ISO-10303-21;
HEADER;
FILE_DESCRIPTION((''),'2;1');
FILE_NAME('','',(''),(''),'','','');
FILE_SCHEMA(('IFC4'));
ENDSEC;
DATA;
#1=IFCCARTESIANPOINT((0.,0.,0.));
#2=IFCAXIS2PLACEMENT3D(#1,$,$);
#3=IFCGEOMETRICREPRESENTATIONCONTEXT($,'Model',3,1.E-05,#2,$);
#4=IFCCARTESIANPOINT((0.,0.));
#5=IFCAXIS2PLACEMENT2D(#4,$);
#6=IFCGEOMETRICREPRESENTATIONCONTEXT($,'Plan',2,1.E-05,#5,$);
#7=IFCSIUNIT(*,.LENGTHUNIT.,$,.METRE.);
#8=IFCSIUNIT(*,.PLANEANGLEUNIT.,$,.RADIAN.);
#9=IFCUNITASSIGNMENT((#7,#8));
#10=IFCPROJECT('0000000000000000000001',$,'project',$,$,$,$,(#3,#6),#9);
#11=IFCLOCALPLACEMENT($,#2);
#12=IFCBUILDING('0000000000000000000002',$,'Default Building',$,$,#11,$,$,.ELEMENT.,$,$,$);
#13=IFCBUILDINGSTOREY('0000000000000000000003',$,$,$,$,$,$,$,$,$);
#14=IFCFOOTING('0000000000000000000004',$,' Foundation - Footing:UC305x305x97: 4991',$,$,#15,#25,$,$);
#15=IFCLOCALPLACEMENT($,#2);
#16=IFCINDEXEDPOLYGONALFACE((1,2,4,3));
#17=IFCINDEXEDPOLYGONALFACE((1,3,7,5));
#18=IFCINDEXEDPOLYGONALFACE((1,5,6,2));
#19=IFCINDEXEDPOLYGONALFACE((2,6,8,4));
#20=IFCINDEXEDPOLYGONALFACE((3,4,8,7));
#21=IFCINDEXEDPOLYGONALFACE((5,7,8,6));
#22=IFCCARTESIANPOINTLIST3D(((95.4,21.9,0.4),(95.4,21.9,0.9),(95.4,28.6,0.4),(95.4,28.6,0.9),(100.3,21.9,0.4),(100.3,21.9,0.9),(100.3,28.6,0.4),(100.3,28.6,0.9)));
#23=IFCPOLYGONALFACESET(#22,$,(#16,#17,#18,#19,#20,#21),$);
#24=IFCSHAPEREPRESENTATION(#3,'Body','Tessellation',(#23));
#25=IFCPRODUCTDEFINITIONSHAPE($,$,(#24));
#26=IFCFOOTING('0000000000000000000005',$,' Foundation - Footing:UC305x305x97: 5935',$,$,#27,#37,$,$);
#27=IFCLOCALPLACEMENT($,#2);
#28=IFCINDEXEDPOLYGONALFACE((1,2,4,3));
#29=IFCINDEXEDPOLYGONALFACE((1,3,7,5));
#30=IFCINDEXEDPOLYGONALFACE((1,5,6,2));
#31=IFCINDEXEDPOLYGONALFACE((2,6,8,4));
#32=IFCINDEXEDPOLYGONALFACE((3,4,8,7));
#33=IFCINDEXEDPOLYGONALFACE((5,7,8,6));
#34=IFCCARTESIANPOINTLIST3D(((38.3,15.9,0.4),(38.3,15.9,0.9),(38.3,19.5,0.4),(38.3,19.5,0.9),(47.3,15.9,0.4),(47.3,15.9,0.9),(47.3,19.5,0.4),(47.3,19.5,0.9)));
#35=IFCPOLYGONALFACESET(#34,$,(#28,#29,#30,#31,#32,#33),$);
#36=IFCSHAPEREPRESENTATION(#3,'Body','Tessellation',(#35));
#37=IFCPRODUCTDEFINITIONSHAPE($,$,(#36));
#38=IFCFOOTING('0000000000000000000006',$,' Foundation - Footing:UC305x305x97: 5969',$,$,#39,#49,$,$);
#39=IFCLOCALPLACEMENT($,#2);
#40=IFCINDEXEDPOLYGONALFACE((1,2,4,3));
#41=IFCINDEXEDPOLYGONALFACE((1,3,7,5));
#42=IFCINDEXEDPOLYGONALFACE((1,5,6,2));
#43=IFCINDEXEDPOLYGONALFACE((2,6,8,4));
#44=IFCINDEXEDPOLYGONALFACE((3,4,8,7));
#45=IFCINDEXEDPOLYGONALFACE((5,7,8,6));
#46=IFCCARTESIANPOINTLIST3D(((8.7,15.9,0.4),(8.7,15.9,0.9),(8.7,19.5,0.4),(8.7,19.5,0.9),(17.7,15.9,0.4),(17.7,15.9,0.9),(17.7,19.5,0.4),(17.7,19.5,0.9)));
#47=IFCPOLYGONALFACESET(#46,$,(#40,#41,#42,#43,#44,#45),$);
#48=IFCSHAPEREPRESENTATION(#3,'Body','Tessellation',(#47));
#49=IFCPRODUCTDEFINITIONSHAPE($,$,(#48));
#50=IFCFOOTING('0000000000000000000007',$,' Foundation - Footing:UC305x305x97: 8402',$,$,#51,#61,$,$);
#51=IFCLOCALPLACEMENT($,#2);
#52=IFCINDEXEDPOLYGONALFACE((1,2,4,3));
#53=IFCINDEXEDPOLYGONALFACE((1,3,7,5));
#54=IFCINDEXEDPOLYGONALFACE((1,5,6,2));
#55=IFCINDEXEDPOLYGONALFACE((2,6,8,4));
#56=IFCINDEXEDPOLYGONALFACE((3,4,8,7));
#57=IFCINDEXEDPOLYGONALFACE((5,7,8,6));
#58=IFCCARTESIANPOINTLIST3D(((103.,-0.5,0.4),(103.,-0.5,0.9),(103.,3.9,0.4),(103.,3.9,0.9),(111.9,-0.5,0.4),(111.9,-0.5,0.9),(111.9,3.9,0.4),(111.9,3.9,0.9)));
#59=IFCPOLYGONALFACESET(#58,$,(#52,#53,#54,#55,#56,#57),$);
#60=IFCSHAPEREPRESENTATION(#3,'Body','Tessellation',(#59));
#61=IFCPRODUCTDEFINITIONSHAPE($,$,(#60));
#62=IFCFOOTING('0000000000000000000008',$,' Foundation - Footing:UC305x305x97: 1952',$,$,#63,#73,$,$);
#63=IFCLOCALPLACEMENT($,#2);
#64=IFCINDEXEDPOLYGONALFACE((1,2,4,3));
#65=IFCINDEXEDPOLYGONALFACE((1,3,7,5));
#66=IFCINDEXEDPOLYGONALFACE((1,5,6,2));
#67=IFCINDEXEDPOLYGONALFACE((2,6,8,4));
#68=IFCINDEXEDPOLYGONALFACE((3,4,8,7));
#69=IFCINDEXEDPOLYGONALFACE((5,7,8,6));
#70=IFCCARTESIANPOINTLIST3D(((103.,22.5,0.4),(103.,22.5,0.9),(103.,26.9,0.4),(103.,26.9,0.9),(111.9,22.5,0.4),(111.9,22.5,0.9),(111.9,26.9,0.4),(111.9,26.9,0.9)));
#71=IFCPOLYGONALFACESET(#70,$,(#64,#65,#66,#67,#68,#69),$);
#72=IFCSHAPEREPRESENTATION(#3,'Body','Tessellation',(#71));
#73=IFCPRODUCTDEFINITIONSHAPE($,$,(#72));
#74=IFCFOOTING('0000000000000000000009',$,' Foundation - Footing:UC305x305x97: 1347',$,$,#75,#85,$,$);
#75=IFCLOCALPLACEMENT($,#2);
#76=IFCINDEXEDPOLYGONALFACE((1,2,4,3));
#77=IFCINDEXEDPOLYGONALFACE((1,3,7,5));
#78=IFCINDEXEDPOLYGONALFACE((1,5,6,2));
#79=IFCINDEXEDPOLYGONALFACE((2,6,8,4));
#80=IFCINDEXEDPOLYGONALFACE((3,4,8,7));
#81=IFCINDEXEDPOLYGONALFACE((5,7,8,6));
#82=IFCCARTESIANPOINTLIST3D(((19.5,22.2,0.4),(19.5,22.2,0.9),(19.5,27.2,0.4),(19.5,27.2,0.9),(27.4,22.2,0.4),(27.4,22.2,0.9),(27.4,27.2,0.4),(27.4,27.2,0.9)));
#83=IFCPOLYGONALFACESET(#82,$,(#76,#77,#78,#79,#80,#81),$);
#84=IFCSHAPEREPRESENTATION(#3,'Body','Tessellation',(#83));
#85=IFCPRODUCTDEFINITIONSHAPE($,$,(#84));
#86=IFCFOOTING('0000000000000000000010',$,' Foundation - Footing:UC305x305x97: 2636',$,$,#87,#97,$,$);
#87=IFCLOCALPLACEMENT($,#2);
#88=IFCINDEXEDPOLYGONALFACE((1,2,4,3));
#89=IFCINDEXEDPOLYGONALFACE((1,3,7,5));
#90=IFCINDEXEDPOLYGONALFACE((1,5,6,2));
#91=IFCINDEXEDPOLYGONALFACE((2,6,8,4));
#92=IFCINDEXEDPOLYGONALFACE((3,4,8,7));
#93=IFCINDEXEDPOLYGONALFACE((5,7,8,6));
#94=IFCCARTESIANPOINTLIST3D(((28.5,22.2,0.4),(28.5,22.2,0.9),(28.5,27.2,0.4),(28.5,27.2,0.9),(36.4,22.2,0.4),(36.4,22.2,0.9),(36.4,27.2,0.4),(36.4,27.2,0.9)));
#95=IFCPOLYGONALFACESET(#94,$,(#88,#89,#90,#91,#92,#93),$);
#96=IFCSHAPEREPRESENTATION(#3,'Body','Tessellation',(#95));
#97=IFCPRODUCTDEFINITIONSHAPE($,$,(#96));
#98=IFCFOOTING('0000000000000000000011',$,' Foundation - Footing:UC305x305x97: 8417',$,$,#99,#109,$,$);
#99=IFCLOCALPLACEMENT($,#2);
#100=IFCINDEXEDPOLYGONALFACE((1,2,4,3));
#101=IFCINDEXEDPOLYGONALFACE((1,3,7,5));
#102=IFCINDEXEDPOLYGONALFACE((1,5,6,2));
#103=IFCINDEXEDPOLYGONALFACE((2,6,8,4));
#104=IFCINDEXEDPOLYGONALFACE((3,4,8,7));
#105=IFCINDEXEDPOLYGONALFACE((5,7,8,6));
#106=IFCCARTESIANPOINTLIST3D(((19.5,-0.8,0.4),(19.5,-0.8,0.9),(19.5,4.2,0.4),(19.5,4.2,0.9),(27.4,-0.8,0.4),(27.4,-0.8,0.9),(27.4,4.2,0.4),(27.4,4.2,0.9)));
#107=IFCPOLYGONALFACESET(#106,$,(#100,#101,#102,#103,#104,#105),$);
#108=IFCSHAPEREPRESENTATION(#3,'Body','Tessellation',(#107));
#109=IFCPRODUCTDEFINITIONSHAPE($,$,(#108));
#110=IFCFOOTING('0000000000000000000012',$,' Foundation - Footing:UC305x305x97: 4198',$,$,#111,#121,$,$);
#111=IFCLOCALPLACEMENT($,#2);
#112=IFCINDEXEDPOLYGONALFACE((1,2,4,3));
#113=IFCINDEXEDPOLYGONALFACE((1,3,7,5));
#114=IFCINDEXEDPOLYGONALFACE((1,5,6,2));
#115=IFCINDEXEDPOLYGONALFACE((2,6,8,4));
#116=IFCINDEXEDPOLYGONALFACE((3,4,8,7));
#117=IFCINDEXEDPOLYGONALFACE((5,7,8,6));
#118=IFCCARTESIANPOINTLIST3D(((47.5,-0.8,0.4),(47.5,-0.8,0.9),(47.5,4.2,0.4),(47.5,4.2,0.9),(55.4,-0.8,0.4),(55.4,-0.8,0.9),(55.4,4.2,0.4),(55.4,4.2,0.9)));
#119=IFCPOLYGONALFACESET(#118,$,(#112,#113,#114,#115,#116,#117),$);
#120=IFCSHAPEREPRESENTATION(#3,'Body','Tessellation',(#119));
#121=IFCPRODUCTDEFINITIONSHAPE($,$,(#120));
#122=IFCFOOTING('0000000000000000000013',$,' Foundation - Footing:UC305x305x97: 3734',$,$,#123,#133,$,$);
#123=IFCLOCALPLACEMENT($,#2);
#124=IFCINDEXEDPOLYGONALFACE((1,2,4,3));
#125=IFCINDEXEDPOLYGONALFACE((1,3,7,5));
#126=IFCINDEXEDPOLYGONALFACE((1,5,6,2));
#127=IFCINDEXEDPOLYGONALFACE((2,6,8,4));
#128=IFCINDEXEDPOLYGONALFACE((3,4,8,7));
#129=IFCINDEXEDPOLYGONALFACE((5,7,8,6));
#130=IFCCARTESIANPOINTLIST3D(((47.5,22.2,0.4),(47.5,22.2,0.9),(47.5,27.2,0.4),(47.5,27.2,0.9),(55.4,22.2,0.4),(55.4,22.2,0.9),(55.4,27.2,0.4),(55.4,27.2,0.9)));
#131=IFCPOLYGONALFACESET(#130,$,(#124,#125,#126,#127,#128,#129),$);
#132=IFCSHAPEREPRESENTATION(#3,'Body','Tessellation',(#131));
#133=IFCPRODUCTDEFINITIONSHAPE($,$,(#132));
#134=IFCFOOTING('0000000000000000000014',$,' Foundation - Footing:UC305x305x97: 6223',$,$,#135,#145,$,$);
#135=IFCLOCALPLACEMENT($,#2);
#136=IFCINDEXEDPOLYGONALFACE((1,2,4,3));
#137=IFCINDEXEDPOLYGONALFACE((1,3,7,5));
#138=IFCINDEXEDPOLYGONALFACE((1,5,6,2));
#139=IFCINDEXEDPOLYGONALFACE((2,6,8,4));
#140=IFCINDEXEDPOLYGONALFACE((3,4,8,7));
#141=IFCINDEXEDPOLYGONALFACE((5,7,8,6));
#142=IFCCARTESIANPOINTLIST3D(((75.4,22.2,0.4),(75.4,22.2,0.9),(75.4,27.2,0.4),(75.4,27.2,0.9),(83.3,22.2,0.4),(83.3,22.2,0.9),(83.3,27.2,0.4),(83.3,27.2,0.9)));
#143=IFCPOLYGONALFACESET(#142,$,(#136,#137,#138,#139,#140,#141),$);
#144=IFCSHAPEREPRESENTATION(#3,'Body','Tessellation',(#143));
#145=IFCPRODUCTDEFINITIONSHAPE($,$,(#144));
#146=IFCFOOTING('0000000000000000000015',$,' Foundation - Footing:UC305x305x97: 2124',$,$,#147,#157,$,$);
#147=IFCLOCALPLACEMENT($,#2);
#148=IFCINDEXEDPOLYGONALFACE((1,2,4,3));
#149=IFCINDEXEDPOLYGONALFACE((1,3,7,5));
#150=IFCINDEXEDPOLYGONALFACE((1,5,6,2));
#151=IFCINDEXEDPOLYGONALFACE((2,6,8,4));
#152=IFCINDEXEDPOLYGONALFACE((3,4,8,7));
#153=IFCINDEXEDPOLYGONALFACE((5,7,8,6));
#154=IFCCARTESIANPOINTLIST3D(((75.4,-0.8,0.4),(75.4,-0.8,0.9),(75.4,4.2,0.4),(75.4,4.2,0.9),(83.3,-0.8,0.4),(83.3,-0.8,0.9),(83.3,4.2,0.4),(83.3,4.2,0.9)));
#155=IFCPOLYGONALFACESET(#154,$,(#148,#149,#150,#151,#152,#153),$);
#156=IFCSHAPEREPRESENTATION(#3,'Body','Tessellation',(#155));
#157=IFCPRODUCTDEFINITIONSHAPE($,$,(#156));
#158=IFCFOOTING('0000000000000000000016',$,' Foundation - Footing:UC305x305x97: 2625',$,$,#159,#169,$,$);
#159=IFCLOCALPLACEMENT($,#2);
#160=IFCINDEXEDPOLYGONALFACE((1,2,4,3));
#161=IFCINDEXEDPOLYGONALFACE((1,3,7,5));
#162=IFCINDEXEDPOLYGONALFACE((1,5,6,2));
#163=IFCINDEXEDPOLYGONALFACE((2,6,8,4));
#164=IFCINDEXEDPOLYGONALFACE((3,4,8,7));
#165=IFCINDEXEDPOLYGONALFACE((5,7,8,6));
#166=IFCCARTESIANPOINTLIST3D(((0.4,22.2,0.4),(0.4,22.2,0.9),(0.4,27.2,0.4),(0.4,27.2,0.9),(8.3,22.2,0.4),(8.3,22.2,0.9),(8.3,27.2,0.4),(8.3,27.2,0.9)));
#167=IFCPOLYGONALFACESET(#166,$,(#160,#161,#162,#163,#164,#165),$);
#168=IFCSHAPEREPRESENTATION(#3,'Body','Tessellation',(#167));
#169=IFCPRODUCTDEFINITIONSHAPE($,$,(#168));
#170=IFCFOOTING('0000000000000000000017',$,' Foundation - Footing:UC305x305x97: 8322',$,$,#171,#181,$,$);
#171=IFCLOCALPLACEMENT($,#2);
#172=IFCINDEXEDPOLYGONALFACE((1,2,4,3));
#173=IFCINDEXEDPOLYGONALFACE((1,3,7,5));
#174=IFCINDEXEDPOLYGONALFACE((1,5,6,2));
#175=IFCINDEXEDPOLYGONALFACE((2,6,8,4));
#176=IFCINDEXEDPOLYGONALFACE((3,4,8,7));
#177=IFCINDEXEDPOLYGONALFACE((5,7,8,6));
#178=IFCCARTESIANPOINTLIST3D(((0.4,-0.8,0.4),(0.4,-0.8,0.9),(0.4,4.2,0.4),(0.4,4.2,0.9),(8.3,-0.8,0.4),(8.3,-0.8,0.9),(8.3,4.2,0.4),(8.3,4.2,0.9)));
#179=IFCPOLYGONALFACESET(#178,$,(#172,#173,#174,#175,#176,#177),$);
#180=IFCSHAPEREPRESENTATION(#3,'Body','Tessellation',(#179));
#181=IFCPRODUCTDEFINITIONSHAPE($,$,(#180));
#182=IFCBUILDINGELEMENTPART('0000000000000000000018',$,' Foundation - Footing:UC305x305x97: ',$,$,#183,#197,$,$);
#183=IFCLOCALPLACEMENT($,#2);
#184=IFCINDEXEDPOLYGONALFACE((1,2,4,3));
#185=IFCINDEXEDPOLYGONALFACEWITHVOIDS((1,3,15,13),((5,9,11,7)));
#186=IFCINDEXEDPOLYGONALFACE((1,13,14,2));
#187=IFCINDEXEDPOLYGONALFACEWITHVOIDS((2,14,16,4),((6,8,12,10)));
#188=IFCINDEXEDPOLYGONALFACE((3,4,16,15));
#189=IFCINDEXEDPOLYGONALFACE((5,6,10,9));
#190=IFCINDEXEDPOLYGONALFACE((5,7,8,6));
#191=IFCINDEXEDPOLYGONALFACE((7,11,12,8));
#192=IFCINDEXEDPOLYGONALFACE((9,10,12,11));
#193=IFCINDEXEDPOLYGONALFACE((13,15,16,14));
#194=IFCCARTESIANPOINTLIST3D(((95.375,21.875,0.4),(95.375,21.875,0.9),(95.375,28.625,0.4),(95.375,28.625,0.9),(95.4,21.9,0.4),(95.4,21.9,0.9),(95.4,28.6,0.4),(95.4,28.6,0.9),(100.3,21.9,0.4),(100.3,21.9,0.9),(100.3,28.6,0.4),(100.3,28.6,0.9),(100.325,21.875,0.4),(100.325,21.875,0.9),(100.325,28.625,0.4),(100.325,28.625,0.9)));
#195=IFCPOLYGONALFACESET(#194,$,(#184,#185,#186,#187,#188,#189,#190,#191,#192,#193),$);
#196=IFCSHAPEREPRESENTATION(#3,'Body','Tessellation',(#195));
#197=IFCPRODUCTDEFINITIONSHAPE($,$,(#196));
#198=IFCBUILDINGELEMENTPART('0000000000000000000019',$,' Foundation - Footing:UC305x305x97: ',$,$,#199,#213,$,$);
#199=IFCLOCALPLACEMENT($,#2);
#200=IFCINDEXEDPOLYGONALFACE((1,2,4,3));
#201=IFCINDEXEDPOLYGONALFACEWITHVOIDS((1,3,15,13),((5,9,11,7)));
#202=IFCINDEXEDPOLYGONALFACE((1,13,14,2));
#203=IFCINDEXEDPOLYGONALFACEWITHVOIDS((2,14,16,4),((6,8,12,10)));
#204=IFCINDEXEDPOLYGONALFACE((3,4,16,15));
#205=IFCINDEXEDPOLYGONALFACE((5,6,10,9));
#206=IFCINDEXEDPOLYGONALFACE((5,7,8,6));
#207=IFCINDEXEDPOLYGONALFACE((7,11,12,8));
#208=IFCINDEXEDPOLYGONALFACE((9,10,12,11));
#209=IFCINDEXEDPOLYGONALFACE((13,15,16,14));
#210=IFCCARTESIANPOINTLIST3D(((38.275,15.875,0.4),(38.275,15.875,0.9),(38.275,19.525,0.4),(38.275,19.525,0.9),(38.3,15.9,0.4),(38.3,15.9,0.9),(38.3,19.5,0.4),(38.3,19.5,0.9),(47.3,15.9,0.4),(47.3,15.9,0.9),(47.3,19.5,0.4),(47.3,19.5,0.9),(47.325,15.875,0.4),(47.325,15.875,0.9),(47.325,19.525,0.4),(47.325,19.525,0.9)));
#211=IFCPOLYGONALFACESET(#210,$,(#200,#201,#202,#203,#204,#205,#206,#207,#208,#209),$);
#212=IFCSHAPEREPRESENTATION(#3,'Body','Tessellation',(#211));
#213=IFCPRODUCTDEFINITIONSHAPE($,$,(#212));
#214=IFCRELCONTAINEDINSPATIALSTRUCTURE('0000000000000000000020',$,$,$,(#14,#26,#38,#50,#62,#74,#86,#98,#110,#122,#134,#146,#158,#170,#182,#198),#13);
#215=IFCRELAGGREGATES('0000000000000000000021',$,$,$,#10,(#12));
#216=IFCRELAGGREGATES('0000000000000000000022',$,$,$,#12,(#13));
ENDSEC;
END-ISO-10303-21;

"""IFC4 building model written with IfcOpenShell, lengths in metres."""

from ifc_helpers import new_model, si_unit, origin, origin_2d, place, context, project, spatial, polyline, outline, extrude, element, save


model = new_model("IFC4")

# Units and contexts
model_context = context("Model", 3, precision=1e-05, world=origin())
plan_context = context("Plan", 2, precision=1e-05, world=origin_2d())
ifc_project = project(units=[si_unit("LENGTHUNIT", "METRE"), si_unit("PLANEANGLEUNIT", "RADIAN")], contexts=[model_context, plan_context])

# Building, storey
building_placement = place(None, origin())
building = spatial("IfcBuilding", under=ifc_project, at=building_placement, Name="Default Building", CompositionType="ELEMENT")
storey = spatial("IfcBuildingStorey", under=building)

# Footings
element("IfcFooting", 1, inside=storey, Name=" Foundation - Footing:UC305x305x97: 4991", context=model_context, shape_type="SweptSolid", body=[
    extrude(outline(polyline([(95.4, 21.9, 0.4), (95.4, 28.6, 0.4), (100.3, 28.6, 0.4), (100.3, 21.9, 0.4), (95.4, 21.9, 0.4)])), None, (0.0, 0.0, 1.0), 0.5),
])
element("IfcFooting", 2, inside=storey, Name=" Foundation - Footing:UC305x305x97: 5935", context=model_context, shape_type="SweptSolid", body=[
    extrude(outline(polyline([(47.3, 19.5, 0.4), (38.3, 19.5, 0.4), (38.3, 15.9, 0.4), (47.3, 15.9, 0.4), (47.3, 19.5, 0.4)])), None, (0.0, 0.0, 1.0), 0.5),
])
element("IfcFooting", 3, inside=storey, Name=" Foundation - Footing:UC305x305x97: 5969", context=model_context, shape_type="SweptSolid", body=[
    extrude(outline(polyline([(17.7, 19.5, 0.4), (8.7, 19.5, 0.4), (8.7, 15.9, 0.4), (17.7, 15.9, 0.4), (17.7, 19.5, 0.4)])), None, (0.0, 0.0, 1.0), 0.5),
])
element("IfcFooting", 4, inside=storey, Name=" Foundation - Footing:UC305x305x97: 8402", context=model_context, shape_type="SweptSolid", body=[
    extrude(outline(polyline([(111.9, 3.9, 0.4), (103.0, 3.9, 0.4), (103.0, -0.5, 0.4), (111.9, -0.5, 0.4), (111.9, 3.9, 0.4)])), None, (0.0, 0.0, 1.0), 0.5),
])
element("IfcFooting", 5, inside=storey, Name=" Foundation - Footing:UC305x305x97: 1952", context=model_context, shape_type="SweptSolid", body=[
    extrude(outline(polyline([(111.9, 26.9, 0.4), (103.0, 26.9, 0.4), (103.0, 22.5, 0.4), (111.9, 22.5, 0.4), (111.9, 26.9, 0.4)])), None, (0.0, 0.0, 1.0), 0.5),
])
element("IfcFooting", 6, inside=storey, Name=" Foundation - Footing:UC305x305x97: 1347", context=model_context, shape_type="SweptSolid", body=[
    extrude(outline(polyline([(27.4, 27.2, 0.4), (19.5, 27.2, 0.4), (19.5, 22.2, 0.4), (27.4, 22.2, 0.4), (27.4, 27.2, 0.4)])), None, (0.0, 0.0, 1.0), 0.5),
])
element("IfcFooting", 7, inside=storey, Name=" Foundation - Footing:UC305x305x97: 2636", context=model_context, shape_type="SweptSolid", body=[
    extrude(outline(polyline([(36.4, 27.2, 0.4), (28.5, 27.2, 0.4), (28.5, 22.2, 0.4), (36.4, 22.2, 0.4), (36.4, 27.2, 0.4)])), None, (0.0, 0.0, 1.0), 0.5),
])
element("IfcFooting", 8, inside=storey, Name=" Foundation - Footing:UC305x305x97: 8417", context=model_context, shape_type="SweptSolid", body=[
    extrude(outline(polyline([(27.4, 4.2, 0.4), (19.5, 4.2, 0.4), (19.5, -0.8, 0.4), (27.4, -0.8, 0.4), (27.4, 4.2, 0.4)])), None, (0.0, 0.0, 1.0), 0.5),
])
element("IfcFooting", 9, inside=storey, Name=" Foundation - Footing:UC305x305x97: 4198", context=model_context, shape_type="SweptSolid", body=[
    extrude(outline(polyline([(55.4, 4.2, 0.4), (47.5, 4.2, 0.4), (47.5, -0.8, 0.4), (55.4, -0.8, 0.4), (55.4, 4.2, 0.4)])), None, (0.0, 0.0, 1.0), 0.5),
])
element("IfcFooting", 10, inside=storey, Name=" Foundation - Footing:UC305x305x97: 3734", context=model_context, shape_type="SweptSolid", body=[
    extrude(outline(polyline([(55.4, 27.2, 0.4), (47.5, 27.2, 0.4), (47.5, 22.2, 0.4), (55.4, 22.2, 0.4), (55.4, 27.2, 0.4)])), None, (0.0, 0.0, 1.0), 0.5),
])
element("IfcFooting", 11, inside=storey, Name=" Foundation - Footing:UC305x305x97: 6223", context=model_context, shape_type="SweptSolid", body=[
    extrude(outline(polyline([(83.3, 27.2, 0.4), (75.4, 27.2, 0.4), (75.4, 22.2, 0.4), (83.3, 22.2, 0.4), (83.3, 27.2, 0.4)])), None, (0.0, 0.0, 1.0), 0.5),
])
element("IfcFooting", 12, inside=storey, Name=" Foundation - Footing:UC305x305x97: 2124", context=model_context, shape_type="SweptSolid", body=[
    extrude(outline(polyline([(83.3, 4.2, 0.4), (75.4, 4.2, 0.4), (75.4, -0.8, 0.4), (83.3, -0.8, 0.4), (83.3, 4.2, 0.4)])), None, (0.0, 0.0, 1.0), 0.5),
])
element("IfcFooting", 13, inside=storey, Name=" Foundation - Footing:UC305x305x97: 2625", context=model_context, shape_type="SweptSolid", body=[
    extrude(outline(polyline([(8.3, 27.2, 0.4), (0.4, 27.2, 0.4), (0.4, 22.2, 0.4), (8.3, 22.2, 0.4), (8.3, 27.2, 0.4)])), None, (0.0, 0.0, 1.0), 0.5),
])
element("IfcFooting", 14, inside=storey, Name=" Foundation - Footing:UC305x305x97: 8322", context=model_context, shape_type="SweptSolid", body=[
    extrude(outline(polyline([(8.3, 4.2, 0.4), (0.4, 4.2, 0.4), (0.4, -0.8, 0.4), (8.3, -0.8, 0.4), (8.3, 4.2, 0.4)])), None, (0.0, 0.0, 1.0), 0.5),
])

# Building element parts, openings
building_element_part_1 = element("IfcBuildingElementPart", 15, inside=storey, Name=" Foundation - Footing:UC305x305x97: ", context=model_context, shape_type="SweptSolid", body=[
    extrude(outline(polyline([(95.375, 21.875, 0.4), (95.375, 28.625, 0.4), (100.325, 28.625, 0.4), (100.325, 21.875, 0.4), (95.375, 21.875, 0.4)])), None, (0.0, 0.0, 1.0), 0.5),
])
element("IfcOpeningElement", 16, inside=storey, cuts=building_element_part_1, context=model_context, shape_type="SweptSolid", body=[
    extrude(outline(polyline([(95.4, 21.9, 0.4), (95.4, 28.6, 0.4), (100.3, 28.6, 0.4), (100.3, 21.9, 0.4), (95.4, 21.9, 0.4)])), None, (0.0, 0.0, 1.0), 0.5),
])
building_element_part_2 = element("IfcBuildingElementPart", 17, inside=storey, Name=" Foundation - Footing:UC305x305x97: ", context=model_context, shape_type="SweptSolid", body=[
    extrude(outline(polyline([(47.325, 19.525, 0.4), (38.275, 19.525, 0.4), (38.275, 15.875, 0.4), (47.325, 15.875, 0.4), (47.325, 19.525, 0.4)])), None, (0.0, 0.0, 1.0), 0.5),
])
element("IfcOpeningElement", 18, inside=storey, cuts=building_element_part_2, context=model_context, shape_type="SweptSolid", body=[
    extrude(outline(polyline([(47.3, 19.5, 0.4), (38.3, 19.5, 0.4), (38.3, 15.9, 0.4), (47.3, 15.9, 0.4), (47.3, 19.5, 0.4)])), None, (0.0, 0.0, 1.0), 0.5),
])

save(model, "model.ifc")
